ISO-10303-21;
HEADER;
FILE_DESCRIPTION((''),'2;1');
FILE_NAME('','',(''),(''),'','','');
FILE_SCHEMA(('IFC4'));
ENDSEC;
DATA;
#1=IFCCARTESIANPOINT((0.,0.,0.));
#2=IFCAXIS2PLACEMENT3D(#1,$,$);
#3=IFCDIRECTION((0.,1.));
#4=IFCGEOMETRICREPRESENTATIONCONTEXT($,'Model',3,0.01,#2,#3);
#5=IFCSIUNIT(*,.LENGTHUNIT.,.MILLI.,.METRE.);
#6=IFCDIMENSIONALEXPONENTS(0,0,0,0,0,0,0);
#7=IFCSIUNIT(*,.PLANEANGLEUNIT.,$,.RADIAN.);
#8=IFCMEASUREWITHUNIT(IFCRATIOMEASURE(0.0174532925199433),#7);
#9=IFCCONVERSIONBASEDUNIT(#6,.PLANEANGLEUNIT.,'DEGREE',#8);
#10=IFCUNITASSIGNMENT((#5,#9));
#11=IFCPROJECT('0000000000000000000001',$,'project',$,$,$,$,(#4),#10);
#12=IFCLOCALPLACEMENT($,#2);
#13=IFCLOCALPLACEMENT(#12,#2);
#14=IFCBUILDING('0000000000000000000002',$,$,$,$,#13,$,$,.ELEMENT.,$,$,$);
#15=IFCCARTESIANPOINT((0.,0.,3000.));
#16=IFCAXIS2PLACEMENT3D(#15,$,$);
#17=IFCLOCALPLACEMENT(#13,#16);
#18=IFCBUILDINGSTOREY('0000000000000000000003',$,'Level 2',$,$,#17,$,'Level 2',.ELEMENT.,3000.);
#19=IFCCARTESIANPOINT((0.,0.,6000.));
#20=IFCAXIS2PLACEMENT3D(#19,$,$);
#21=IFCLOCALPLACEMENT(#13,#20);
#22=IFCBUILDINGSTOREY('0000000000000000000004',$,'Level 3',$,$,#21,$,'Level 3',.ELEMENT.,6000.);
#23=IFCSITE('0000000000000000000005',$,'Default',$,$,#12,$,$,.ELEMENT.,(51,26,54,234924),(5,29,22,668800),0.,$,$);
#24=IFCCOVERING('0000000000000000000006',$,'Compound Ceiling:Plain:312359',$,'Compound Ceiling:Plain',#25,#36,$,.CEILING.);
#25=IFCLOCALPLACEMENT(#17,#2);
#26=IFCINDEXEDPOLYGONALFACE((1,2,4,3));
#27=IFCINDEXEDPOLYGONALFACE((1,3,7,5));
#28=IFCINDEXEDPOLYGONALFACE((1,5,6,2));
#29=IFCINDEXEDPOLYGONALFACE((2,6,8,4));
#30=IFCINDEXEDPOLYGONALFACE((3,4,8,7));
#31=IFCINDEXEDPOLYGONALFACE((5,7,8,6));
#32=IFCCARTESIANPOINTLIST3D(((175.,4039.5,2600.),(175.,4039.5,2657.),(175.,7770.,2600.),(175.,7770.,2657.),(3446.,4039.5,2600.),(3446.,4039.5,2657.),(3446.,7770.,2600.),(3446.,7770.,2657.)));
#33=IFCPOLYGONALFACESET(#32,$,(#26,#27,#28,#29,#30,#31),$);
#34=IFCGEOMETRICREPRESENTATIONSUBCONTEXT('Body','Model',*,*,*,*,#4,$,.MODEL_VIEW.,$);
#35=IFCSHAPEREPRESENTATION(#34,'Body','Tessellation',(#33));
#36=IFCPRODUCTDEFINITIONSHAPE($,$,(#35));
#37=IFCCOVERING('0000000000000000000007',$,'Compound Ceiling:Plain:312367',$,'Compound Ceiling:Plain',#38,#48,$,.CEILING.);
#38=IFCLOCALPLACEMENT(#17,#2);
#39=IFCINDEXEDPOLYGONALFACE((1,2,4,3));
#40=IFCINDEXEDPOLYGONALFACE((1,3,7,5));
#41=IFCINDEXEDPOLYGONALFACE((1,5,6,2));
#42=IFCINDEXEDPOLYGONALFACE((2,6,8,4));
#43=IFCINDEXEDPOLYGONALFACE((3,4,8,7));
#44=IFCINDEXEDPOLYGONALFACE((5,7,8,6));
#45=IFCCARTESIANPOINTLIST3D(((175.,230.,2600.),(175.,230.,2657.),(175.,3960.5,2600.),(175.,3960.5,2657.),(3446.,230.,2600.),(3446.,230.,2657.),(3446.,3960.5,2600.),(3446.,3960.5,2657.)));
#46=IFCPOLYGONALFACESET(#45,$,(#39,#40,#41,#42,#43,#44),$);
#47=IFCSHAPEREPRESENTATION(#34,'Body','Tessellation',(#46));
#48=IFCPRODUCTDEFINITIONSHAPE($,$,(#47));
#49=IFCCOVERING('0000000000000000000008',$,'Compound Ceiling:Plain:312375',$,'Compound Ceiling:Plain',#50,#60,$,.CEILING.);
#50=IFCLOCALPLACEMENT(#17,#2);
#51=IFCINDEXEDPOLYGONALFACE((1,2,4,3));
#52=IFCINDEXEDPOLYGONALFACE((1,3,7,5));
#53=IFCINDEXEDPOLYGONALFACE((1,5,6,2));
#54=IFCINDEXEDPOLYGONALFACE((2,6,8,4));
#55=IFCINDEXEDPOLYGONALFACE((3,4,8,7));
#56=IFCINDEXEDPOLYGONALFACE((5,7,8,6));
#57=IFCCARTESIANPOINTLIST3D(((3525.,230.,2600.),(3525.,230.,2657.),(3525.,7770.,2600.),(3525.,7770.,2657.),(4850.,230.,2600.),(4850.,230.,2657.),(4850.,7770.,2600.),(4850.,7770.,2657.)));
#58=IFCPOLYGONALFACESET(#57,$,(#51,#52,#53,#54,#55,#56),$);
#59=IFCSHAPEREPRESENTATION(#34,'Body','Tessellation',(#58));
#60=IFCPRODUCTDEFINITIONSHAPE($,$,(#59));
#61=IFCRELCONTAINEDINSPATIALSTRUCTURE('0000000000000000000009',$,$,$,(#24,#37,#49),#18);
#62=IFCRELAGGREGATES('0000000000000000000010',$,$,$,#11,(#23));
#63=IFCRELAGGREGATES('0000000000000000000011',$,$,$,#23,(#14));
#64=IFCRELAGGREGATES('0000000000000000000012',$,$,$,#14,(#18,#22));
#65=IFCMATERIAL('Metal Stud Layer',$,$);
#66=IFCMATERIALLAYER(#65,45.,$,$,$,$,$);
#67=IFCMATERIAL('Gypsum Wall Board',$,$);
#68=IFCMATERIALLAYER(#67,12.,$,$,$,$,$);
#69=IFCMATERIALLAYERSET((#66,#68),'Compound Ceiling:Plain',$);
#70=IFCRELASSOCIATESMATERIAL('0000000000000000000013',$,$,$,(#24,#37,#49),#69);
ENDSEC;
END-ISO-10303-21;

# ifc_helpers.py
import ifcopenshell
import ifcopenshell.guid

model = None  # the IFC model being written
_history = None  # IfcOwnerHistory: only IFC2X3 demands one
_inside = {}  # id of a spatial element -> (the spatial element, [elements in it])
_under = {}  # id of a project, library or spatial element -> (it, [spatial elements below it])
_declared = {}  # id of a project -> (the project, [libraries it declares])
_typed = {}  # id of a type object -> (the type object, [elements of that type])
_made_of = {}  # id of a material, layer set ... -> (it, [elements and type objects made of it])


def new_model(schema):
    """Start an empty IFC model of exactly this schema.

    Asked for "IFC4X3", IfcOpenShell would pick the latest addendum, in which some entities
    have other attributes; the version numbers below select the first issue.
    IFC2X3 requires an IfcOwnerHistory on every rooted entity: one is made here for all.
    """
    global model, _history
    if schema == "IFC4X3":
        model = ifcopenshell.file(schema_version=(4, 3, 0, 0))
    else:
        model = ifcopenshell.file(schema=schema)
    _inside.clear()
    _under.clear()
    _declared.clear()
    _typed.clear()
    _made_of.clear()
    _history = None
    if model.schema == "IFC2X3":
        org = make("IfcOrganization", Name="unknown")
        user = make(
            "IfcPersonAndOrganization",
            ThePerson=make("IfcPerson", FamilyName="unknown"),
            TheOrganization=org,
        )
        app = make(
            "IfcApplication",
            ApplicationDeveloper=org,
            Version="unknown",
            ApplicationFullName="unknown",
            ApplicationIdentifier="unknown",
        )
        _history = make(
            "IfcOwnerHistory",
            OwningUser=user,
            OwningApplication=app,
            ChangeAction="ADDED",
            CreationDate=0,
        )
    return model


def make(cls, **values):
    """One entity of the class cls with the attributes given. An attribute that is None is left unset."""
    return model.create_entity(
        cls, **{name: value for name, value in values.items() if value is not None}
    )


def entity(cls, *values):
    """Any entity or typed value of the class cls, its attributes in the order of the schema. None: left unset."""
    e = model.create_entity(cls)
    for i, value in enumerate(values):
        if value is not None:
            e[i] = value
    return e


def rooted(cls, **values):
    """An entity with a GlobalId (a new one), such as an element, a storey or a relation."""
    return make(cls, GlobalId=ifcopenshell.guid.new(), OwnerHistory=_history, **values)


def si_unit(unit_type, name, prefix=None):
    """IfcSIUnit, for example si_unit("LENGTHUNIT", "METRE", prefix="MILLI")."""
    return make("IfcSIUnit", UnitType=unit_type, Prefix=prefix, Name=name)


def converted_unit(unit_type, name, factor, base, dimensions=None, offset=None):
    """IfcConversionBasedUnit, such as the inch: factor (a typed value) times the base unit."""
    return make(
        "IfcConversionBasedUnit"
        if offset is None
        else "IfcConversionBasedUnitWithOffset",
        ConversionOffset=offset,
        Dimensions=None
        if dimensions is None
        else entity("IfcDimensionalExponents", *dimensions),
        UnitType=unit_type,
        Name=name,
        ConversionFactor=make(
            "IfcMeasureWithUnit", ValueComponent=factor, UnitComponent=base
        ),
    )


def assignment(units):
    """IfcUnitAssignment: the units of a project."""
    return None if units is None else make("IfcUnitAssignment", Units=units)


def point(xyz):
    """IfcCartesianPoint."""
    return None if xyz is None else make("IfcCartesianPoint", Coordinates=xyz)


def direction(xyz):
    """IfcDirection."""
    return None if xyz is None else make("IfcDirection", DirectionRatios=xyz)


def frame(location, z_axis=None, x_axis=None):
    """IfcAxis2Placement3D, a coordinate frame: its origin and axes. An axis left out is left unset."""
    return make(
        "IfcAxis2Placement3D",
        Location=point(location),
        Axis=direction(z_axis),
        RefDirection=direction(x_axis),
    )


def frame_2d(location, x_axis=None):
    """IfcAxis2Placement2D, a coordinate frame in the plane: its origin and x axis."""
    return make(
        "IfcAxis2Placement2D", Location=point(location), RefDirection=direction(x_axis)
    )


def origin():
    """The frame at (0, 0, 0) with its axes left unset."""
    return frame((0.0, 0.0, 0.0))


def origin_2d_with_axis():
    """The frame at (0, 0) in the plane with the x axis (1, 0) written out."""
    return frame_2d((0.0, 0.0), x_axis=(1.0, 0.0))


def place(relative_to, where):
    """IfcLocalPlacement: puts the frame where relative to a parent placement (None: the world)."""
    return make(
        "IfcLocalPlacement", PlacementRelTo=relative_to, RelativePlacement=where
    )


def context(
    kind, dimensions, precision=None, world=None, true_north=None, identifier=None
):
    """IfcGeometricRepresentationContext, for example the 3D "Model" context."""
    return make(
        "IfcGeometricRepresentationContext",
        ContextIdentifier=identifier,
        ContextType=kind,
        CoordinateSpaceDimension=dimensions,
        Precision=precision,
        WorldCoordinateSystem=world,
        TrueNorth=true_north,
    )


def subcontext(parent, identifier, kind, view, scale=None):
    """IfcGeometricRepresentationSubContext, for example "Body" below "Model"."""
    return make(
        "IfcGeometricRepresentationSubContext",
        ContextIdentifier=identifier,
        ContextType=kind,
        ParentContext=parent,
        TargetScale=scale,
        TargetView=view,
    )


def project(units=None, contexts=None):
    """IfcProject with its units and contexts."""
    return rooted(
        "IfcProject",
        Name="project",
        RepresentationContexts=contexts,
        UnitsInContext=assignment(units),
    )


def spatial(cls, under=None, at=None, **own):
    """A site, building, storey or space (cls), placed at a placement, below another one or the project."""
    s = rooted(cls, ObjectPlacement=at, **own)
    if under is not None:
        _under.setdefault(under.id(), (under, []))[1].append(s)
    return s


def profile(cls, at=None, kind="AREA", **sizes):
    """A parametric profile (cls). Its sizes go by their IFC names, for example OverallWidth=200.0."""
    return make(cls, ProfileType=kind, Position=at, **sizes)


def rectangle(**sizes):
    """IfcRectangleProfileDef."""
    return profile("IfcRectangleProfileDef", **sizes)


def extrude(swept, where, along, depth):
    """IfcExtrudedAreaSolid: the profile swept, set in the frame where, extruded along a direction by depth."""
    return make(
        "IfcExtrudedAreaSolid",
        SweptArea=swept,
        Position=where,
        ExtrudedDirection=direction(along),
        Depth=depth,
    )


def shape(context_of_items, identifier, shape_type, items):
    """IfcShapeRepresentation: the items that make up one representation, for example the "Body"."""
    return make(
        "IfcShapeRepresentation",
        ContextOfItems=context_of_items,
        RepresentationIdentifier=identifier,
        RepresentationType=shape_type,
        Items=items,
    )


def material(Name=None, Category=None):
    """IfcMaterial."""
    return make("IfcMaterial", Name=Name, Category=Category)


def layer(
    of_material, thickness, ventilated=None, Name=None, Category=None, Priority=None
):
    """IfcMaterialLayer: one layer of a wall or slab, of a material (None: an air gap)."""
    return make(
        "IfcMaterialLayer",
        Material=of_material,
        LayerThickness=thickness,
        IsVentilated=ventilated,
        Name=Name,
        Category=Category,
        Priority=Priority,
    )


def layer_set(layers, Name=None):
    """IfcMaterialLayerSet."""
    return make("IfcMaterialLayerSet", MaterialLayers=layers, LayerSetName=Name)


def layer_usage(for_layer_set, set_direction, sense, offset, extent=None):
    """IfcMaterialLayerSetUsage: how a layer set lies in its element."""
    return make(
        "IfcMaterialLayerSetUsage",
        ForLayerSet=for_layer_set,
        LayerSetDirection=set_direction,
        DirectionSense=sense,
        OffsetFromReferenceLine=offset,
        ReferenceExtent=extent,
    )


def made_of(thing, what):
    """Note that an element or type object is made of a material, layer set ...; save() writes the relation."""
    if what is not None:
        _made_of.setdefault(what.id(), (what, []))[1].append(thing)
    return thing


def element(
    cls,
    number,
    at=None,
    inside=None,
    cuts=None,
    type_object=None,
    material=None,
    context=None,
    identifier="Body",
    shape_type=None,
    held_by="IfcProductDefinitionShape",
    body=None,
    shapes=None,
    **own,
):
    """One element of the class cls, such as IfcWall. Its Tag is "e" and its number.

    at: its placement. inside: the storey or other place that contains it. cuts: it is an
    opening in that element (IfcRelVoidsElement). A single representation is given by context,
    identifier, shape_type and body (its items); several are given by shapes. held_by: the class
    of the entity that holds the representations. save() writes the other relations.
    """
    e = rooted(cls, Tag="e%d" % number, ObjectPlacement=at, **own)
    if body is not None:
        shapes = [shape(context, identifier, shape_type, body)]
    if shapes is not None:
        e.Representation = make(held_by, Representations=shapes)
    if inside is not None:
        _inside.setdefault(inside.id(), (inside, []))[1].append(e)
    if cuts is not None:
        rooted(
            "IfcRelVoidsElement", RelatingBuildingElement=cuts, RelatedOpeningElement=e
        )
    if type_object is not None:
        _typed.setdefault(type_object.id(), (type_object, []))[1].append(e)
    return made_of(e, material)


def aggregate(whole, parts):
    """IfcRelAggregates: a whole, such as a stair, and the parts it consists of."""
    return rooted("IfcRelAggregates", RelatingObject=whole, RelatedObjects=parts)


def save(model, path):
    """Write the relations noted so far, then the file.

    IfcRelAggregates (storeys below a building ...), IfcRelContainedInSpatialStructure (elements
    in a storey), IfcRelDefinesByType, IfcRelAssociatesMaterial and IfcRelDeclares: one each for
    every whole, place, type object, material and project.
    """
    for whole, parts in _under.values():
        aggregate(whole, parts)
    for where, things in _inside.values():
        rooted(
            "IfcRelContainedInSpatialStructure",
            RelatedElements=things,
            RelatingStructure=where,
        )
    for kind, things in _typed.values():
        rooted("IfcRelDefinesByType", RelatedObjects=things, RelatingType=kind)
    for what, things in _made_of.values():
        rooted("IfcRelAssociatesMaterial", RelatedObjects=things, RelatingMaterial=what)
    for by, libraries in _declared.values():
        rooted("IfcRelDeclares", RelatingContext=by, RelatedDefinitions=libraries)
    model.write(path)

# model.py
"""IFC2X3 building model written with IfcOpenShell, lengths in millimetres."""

from ifc_helpers import new_model, entity, si_unit, converted_unit, direction, frame, frame_2d, origin, origin_2d_with_axis, place, context, subcontext, project, spatial, rectangle, extrude, material, layer, layer_set, layer_usage, element, save


model = new_model("IFC2X3")

# Units and contexts
model_context = context("Model", 3, precision=0.01, world=origin(), true_north=direction((0.0, 1.0)))
body_context = subcontext(model_context, "Body", "Model", "MODEL_VIEW")
ifc_project = project(units=[si_unit("LENGTHUNIT", "METRE", prefix="MILLI"), converted_unit("PLANEANGLEUNIT", "DEGREE", entity("IfcRatioMeasure", 0.0174532925199433), si_unit("PLANEANGLEUNIT", "RADIAN"), dimensions=[0, 0, 0, 0, 0, 0, 0])], contexts=[model_context])

# Site, building, storey
site_placement = place(None, origin())
site = spatial("IfcSite", under=ifc_project, at=site_placement, Name="Default", CompositionType="ELEMENT", RefLatitude=(51, 26, 54, 234924), RefLongitude=(5, 29, 22, 668800), RefElevation=0.0)
building_placement = place(site_placement, origin())
building = spatial("IfcBuilding", under=site, at=building_placement, CompositionType="ELEMENT")
storey_1_placement = place(building_placement, frame((0.0, 0.0, 3000.0)))
storey_1 = spatial("IfcBuildingStorey", under=building, at=storey_1_placement, Name="Level 2", LongName="Level 2", CompositionType="ELEMENT", Elevation=3000.0)

# Shared definitions
ifc_material_1 = material(Name="Metal Stud Layer")
ifc_material_2 = material(Name="Gypsum Wall Board")

# Shared definitions
storey_2_placement = place(building_placement, frame((0.0, 0.0, 6000.0)))
storey_2 = spatial("IfcBuildingStorey", under=building, at=storey_2_placement, Name="Level 3", LongName="Level 3", CompositionType="ELEMENT", Elevation=6000.0)

# Coverings
ifc_layer_1 = layer(ifc_material_1, 45.0)
ifc_layer_2 = layer(ifc_material_2, 12.0)
ifc_layer_set_1 = layer_set([ifc_layer_1, ifc_layer_2], Name="Compound Ceiling:Plain")
ifc_layer_usage_1 = layer_usage(ifc_layer_set_1, "AXIS3", "NEGATIVE", 0.0)
covering_1_placement = place(storey_1_placement, origin())
element("IfcCovering", 1, at=covering_1_placement, inside=storey_1, material=ifc_layer_usage_1, Name="Compound Ceiling:Plain:312359", ObjectType="Compound Ceiling:Plain", PredefinedType="CEILING", context=body_context, shape_type="SweptSolid", body=[
    extrude(rectangle(XDim=3271.0, YDim=3730.5, at=frame_2d((0.0, 0.0), x_axis=(1.0, 0.0))), frame((1810.5, 5904.8, 2600.0)), (0.0, 0.0, 1.0), 57.0),
])
ifc_layer_usage_2 = layer_usage(ifc_layer_set_1, "AXIS3", "NEGATIVE", 0.0)
covering_2_placement = place(storey_1_placement, origin())
element("IfcCovering", 2, at=covering_2_placement, inside=storey_1, material=ifc_layer_usage_2, Name="Compound Ceiling:Plain:312367", ObjectType="Compound Ceiling:Plain", PredefinedType="CEILING", context=body_context, shape_type="SweptSolid", body=[
    extrude(rectangle(XDim=3271.0, YDim=3730.5, at=origin_2d_with_axis()), frame((1810.5, 2095.2, 2600.0)), (0.0, 0.0, 1.0), 57.0),
])
ifc_layer_usage_3 = layer_usage(ifc_layer_set_1, "AXIS3", "NEGATIVE", 0.0)
covering_3_placement = place(storey_1_placement, origin())
element("IfcCovering", 3, at=covering_3_placement, inside=storey_1, material=ifc_layer_usage_3, Name="Compound Ceiling:Plain:312375", ObjectType="Compound Ceiling:Plain", PredefinedType="CEILING", context=body_context, shape_type="SweptSolid", body=[
    extrude(rectangle(XDim=1325.0, YDim=7540.0, at=frame_2d((0.0, 0.0), x_axis=(1.0, 0.0))), frame((4187.5, 4000.0, 2600.0)), (0.0, 0.0, 1.0), 57.0),
])

save(model, "model.ifc")
